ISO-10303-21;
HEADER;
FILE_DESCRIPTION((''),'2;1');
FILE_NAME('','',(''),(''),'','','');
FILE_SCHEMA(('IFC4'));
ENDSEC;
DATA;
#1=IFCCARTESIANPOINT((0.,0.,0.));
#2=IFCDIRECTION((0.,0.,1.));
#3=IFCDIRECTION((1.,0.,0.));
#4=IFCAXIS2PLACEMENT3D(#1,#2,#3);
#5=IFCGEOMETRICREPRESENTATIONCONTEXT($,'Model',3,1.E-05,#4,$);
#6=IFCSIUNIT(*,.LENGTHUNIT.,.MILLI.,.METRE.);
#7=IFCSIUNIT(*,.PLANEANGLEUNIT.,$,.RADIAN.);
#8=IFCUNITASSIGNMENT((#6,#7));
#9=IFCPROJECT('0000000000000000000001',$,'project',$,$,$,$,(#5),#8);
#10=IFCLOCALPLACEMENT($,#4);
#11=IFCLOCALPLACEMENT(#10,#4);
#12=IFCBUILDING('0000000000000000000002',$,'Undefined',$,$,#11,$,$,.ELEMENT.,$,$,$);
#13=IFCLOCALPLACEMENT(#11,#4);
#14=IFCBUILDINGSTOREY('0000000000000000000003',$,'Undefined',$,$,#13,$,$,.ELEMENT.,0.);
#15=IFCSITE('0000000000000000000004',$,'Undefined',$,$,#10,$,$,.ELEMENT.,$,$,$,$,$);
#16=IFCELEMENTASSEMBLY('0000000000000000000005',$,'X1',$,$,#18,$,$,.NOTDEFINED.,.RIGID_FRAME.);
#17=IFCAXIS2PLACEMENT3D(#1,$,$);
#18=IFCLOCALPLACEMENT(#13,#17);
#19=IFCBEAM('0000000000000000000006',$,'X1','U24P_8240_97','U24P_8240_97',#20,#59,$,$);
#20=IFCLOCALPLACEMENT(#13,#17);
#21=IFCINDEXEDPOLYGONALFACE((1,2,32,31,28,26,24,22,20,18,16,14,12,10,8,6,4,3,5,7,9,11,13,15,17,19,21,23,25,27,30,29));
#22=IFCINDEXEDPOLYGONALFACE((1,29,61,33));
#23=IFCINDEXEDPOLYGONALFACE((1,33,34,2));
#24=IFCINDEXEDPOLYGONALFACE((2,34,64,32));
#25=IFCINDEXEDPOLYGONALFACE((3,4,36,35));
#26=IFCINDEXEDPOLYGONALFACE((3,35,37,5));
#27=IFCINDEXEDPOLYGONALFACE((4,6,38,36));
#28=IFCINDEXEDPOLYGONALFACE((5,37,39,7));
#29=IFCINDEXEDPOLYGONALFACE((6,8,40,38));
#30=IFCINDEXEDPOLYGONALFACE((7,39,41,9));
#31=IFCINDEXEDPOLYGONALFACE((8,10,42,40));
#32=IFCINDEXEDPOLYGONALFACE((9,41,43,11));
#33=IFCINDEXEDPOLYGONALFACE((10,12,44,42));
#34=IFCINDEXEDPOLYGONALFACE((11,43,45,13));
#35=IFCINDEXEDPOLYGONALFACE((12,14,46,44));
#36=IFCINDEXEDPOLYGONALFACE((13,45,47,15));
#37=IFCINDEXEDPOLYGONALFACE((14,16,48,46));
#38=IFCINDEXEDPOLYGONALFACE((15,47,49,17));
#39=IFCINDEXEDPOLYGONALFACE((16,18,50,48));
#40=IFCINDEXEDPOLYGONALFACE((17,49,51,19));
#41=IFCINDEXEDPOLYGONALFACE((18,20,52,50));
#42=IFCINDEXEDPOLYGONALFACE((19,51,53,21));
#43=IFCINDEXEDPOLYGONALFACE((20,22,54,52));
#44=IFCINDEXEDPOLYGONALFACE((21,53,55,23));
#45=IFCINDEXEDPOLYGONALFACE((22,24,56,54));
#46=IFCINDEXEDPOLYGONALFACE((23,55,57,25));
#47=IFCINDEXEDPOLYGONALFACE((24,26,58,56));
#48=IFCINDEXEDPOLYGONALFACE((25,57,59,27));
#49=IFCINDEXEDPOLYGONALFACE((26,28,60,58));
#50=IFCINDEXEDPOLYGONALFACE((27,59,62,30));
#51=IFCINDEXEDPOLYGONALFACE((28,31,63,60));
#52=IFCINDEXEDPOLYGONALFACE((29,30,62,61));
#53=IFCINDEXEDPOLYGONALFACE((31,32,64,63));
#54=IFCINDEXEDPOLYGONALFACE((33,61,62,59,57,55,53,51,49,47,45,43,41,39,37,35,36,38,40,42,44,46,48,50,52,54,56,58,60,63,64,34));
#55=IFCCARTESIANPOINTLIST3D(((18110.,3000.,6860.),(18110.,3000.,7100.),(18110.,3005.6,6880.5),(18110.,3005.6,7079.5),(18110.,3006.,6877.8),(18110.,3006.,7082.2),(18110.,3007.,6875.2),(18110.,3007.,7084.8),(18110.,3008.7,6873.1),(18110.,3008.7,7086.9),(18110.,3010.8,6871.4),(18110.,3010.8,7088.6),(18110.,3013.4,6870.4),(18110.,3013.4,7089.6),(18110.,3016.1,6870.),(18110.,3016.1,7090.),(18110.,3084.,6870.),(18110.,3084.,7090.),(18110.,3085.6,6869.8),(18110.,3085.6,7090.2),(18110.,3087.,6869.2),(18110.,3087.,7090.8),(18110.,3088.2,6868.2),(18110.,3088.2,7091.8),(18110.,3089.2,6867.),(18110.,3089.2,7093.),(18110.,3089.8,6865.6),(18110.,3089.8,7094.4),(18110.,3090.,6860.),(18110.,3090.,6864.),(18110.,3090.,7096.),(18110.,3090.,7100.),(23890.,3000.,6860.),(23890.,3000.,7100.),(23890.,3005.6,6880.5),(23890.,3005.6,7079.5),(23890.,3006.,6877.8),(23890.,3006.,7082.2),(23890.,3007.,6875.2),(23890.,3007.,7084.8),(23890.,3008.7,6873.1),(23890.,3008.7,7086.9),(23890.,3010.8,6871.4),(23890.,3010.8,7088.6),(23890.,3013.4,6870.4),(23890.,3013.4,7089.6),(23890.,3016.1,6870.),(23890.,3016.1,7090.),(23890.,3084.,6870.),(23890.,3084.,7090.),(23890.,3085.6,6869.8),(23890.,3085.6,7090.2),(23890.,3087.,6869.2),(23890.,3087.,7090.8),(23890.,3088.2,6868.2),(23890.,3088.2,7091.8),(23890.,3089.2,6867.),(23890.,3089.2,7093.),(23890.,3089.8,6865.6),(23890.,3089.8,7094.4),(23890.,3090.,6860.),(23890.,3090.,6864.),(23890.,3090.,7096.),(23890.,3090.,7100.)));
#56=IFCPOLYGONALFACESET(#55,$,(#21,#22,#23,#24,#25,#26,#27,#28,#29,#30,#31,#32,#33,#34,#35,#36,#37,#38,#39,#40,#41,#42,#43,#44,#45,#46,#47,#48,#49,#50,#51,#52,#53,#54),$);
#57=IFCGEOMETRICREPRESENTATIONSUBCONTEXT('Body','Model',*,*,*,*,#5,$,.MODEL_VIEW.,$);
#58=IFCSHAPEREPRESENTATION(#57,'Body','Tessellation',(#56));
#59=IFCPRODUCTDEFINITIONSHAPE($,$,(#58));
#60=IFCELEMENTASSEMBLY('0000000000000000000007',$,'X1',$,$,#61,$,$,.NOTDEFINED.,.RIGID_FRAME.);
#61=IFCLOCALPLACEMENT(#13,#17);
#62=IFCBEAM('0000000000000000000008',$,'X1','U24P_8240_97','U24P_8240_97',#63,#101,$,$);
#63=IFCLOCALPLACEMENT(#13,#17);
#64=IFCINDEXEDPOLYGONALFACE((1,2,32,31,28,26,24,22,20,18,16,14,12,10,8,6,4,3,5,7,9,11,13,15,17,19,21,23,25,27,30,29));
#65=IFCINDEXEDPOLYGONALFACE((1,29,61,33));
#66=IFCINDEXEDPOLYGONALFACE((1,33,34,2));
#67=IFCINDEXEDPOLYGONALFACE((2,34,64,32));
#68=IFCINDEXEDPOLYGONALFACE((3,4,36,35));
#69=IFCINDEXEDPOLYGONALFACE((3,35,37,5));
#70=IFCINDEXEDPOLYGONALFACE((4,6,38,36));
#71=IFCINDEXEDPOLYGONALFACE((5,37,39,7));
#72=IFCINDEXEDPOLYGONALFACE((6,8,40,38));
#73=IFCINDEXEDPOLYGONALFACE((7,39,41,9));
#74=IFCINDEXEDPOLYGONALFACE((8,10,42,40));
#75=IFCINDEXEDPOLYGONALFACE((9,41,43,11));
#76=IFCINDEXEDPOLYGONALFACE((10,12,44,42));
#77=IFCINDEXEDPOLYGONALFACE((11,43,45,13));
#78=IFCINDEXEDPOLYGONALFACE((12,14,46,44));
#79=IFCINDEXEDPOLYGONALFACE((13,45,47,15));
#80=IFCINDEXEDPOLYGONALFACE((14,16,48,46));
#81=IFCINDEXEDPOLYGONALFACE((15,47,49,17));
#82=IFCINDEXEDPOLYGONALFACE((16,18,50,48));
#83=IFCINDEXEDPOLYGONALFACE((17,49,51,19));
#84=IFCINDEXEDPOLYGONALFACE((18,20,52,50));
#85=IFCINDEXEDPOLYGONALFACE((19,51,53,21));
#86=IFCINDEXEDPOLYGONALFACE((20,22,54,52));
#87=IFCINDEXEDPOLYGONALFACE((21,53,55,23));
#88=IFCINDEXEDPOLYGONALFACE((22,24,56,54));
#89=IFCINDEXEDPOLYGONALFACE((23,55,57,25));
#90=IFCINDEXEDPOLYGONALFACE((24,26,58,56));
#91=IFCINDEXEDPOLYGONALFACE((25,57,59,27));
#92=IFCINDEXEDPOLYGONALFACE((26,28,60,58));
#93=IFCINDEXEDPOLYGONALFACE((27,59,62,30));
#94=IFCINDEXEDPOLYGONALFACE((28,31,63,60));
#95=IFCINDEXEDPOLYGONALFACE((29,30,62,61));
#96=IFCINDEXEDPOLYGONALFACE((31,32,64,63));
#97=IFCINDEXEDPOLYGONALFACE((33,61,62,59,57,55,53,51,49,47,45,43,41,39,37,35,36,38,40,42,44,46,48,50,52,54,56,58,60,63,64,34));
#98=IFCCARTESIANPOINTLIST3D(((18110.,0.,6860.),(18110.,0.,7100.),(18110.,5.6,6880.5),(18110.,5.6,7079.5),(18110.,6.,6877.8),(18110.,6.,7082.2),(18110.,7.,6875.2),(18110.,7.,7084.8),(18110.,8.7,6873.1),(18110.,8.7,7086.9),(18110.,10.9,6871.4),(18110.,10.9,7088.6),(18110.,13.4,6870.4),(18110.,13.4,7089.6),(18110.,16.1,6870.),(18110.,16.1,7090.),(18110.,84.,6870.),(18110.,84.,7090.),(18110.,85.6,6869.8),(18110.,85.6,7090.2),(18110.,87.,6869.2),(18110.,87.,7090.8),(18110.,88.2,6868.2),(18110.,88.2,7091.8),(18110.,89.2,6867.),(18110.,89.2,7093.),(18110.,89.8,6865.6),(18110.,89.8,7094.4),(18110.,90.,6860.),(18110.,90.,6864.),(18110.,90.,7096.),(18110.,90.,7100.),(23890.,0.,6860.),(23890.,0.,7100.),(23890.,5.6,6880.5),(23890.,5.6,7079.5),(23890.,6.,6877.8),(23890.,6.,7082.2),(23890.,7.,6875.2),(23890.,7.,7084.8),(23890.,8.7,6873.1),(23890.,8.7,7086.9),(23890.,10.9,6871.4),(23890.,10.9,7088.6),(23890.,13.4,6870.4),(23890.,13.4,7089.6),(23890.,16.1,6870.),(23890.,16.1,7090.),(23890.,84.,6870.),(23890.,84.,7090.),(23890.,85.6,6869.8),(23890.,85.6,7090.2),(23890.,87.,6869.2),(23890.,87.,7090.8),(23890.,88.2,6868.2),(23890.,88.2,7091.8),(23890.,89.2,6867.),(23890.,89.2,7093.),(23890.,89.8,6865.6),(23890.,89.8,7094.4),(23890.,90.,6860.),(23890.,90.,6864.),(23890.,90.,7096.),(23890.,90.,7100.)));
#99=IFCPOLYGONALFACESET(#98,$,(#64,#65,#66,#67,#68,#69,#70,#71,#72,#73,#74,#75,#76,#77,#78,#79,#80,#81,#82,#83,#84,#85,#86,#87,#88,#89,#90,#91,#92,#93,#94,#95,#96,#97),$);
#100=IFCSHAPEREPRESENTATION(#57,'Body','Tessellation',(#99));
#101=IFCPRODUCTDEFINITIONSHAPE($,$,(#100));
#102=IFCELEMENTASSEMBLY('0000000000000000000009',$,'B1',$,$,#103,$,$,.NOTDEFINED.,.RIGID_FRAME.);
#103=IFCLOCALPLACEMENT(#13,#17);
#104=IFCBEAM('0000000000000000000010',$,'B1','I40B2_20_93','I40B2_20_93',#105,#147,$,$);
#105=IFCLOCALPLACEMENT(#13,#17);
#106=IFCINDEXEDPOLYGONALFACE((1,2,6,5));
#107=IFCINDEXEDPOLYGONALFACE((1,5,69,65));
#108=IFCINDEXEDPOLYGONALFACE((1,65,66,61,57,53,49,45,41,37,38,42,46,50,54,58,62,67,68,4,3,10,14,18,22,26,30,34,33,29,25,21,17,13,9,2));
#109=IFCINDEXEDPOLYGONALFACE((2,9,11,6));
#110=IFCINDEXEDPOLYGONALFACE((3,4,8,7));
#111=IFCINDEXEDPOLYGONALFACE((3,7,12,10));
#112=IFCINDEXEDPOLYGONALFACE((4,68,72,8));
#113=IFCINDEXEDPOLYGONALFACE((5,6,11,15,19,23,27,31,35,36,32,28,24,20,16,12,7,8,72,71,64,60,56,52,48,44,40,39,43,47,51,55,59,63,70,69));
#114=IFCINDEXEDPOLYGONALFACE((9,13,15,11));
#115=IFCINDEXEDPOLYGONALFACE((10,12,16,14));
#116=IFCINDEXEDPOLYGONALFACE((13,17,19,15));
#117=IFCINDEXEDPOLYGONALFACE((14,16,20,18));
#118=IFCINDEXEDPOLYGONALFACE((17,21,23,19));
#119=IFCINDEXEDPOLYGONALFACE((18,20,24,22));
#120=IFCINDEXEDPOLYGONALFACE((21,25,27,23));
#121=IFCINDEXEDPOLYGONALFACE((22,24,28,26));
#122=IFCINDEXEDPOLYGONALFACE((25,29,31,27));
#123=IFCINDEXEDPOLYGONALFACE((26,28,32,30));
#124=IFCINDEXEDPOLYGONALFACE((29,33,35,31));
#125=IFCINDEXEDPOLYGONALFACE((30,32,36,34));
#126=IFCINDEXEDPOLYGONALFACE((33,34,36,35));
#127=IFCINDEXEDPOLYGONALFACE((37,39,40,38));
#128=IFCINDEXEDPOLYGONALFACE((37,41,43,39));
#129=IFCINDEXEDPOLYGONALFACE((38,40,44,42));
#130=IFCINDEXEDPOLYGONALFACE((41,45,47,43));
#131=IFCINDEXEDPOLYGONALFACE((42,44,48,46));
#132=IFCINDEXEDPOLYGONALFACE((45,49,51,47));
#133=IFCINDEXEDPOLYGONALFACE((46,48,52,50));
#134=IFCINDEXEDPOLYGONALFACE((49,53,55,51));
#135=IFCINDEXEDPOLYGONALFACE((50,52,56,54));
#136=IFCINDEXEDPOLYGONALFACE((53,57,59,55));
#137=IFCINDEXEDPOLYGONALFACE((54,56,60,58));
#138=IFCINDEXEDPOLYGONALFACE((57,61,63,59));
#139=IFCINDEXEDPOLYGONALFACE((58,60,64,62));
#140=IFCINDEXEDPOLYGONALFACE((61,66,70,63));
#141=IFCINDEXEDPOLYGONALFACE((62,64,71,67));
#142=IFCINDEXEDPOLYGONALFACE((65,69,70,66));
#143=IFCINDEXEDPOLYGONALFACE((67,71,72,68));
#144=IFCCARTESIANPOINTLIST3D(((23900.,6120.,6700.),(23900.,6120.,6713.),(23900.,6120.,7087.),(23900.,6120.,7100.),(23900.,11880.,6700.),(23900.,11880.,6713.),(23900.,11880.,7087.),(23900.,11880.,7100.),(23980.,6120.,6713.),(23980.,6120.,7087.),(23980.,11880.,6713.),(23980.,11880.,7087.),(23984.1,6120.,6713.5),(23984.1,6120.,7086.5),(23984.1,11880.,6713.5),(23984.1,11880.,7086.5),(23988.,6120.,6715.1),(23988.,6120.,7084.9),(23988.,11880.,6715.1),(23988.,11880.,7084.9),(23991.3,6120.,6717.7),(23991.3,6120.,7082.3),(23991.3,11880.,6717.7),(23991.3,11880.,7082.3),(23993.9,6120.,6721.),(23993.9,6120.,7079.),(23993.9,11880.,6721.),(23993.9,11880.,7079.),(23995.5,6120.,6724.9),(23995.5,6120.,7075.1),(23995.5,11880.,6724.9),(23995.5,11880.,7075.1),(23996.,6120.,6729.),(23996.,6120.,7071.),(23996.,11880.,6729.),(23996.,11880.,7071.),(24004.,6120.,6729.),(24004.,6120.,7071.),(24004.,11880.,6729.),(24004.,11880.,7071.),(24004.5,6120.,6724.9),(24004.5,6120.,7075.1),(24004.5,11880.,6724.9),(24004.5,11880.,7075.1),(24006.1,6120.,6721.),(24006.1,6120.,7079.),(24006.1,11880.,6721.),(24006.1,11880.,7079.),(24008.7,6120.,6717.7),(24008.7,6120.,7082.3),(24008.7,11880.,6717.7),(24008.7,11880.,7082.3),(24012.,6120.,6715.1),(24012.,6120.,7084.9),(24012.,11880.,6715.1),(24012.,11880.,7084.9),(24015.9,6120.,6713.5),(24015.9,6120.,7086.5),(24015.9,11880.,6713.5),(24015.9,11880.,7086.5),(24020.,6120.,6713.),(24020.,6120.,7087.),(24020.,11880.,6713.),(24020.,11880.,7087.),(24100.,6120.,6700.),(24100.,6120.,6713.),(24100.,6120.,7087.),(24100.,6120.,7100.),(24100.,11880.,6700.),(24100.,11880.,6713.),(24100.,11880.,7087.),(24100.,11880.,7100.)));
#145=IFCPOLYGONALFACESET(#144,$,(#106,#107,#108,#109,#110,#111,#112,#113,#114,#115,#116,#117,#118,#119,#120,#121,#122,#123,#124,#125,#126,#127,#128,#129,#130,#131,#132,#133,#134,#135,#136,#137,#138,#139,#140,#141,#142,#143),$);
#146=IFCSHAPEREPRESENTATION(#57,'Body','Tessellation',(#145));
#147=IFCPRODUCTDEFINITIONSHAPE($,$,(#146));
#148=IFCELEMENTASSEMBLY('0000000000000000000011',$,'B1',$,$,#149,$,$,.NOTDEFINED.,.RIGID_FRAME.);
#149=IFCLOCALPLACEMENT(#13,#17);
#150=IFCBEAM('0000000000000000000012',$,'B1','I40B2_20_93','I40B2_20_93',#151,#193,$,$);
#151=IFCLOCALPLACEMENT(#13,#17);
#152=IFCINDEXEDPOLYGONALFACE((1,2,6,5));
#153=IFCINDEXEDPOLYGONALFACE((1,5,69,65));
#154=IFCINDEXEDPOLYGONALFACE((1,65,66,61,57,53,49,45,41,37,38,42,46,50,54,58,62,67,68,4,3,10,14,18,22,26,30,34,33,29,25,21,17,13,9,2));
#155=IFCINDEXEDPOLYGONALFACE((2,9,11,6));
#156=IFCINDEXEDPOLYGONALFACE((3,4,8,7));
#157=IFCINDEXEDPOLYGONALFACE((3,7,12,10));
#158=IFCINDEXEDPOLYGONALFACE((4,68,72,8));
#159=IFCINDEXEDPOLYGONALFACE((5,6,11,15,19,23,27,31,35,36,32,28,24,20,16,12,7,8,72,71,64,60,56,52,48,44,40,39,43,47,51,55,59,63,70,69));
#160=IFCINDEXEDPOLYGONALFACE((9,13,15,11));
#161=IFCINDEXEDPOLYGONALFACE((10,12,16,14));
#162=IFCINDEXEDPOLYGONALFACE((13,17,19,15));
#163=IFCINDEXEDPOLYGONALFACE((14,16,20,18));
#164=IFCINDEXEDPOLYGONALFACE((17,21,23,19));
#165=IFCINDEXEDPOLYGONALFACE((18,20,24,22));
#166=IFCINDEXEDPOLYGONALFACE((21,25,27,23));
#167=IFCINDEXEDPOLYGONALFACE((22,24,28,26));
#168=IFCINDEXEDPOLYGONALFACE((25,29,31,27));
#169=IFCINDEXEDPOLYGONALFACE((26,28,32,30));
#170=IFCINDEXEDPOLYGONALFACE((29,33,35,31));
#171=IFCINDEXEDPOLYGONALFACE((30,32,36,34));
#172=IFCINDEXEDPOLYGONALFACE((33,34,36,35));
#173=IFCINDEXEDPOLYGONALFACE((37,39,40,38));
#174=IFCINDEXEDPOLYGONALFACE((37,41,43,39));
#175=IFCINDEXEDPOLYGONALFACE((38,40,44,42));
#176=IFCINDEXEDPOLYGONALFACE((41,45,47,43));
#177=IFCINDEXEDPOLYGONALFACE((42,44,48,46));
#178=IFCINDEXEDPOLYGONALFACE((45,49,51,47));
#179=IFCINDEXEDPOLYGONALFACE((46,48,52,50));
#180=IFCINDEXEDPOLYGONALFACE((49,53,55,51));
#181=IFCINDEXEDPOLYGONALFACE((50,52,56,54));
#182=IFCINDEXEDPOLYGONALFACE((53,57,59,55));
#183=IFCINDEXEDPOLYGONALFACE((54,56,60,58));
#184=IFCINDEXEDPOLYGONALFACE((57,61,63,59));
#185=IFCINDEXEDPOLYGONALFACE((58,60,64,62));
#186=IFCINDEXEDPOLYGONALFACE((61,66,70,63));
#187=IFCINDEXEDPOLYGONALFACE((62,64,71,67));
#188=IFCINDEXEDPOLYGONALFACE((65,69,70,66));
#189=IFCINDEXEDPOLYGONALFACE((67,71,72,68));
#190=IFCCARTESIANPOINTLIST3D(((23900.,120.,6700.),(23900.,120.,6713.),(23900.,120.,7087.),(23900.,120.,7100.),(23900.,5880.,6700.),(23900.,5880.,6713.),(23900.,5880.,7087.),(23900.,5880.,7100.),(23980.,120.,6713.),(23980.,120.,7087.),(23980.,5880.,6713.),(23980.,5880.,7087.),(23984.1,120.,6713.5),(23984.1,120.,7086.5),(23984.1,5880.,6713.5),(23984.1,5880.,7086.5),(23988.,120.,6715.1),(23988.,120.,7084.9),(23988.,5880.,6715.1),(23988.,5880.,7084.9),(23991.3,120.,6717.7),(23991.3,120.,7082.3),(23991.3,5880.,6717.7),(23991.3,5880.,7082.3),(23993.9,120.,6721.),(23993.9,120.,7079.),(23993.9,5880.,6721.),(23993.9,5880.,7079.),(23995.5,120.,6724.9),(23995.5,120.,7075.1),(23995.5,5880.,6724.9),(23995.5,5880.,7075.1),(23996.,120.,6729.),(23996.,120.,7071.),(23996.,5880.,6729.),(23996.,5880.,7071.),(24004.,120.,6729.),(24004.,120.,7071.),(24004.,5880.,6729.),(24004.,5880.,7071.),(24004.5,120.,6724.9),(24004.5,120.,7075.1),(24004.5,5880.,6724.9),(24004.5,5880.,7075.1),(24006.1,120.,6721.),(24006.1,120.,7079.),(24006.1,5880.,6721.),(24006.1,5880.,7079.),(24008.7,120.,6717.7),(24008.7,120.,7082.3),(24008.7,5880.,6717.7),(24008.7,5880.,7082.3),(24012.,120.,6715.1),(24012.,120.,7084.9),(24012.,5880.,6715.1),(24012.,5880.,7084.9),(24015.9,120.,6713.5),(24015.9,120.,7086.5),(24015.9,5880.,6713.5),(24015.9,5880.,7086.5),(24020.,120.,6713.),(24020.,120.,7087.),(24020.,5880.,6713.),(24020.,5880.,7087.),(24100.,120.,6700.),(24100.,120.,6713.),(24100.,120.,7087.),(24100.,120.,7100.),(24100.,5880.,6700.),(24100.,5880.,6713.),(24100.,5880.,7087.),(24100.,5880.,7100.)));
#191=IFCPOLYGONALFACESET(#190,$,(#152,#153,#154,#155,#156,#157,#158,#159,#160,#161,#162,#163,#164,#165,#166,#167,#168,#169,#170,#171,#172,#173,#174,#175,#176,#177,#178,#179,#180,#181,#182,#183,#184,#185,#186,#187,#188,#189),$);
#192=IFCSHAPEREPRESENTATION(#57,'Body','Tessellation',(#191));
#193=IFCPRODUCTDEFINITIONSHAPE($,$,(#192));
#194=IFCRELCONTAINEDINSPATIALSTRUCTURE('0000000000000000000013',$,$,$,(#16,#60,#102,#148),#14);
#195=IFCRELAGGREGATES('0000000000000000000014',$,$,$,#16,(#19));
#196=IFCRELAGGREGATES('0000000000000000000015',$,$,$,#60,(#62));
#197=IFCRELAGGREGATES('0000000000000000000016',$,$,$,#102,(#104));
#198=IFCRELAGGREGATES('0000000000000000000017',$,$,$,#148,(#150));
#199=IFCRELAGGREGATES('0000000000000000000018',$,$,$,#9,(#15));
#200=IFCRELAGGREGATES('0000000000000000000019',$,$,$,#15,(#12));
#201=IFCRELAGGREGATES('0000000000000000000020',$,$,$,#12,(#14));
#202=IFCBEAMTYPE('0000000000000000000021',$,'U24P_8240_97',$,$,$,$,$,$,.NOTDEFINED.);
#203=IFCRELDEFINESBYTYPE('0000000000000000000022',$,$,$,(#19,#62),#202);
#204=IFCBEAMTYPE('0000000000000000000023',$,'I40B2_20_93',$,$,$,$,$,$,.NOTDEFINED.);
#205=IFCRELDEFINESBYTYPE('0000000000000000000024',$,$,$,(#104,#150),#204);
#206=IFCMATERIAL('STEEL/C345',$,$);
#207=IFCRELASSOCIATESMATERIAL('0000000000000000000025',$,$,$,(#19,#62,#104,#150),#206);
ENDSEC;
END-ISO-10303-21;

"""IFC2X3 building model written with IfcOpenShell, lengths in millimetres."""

from ifc_helpers import new_model, si_unit, frame, origin_with_axes, origin_2d_with_axis, place, context, subcontext, project, spatial, i_section, u_section, extrude, material, type_object, element, aggregate, save


model = new_model("IFC2X3")

# Units and contexts
model_context = context("Model", 3, precision=1e-05, world=origin_with_axes())
body_context = subcontext(model_context, "Body", "Model", "MODEL_VIEW")
ifc_project = project(units=[si_unit("LENGTHUNIT", "METRE", prefix="MILLI"), si_unit("PLANEANGLEUNIT", "RADIAN")], contexts=[model_context])

# Site, building, storey
site_placement = place(None, origin_with_axes())
site = spatial("IfcSite", under=ifc_project, at=site_placement, Name="Undefined", CompositionType="ELEMENT")
building_placement = place(site_placement, origin_with_axes())
building = spatial("IfcBuilding", under=site, at=building_placement, Name="Undefined", CompositionType="ELEMENT")
storey_placement = place(building_placement, origin_with_axes())
storey = spatial("IfcBuildingStorey", under=building, at=storey_placement, Name="Undefined", CompositionType="ELEMENT", Elevation=0.0)

# Element assemblies, beams
ifc_material_1 = material(Name="STEEL/C345")
beam_type_1 = type_object("IfcBeamType", Name="U24P_8240_97", PredefinedType="NOTDEFINED")
assembly_1_placement = place(storey_placement, origin_with_axes())
assembly_1 = element("IfcElementAssembly", 1, at=assembly_1_placement, inside=storey, Name="X1", AssemblyPlace="NOTDEFINED", PredefinedType="RIGID_FRAME")
beam_1_placement = place(assembly_1_placement, frame((18110.0, 3045.0, 6980.0), z_axis=(0.0, 0.0, -1.0), x_axis=(1.0, 0.0, 0.0)))
beam_1 = element("IfcBeam", 2, at=beam_1_placement, type_object=beam_type_1, material=ifc_material_1, Name="X1", Description="U24P_8240_97", ObjectType="U24P_8240_97", context=body_context, shape_type="SweptSolid", body=[
    extrude(u_section(Depth=240.0, FlangeWidth=90.0, WebThickness=5.6, FlangeThickness=10.0, FilletRadius=10.5, EdgeRadius=6.0, at=origin_2d_with_axis()), frame((5780.0, 0.0, 0.0), z_axis=(-1.0, 0.0, 0.0), x_axis=(0.0, -1.0, 0.0)), (0.0, 0.0, 1.0), 5780.0),
])
aggregate(assembly_1, [beam_1])
assembly_2_placement = place(storey_placement, origin_with_axes())
assembly_2 = element("IfcElementAssembly", 3, at=assembly_2_placement, inside=storey, Name="X1", AssemblyPlace="NOTDEFINED", PredefinedType="RIGID_FRAME")
beam_2_placement = place(assembly_2_placement, frame((18110.0, 45.0, 6980.0), z_axis=(0.0, 0.0, -1.0), x_axis=(1.0, 0.0, 0.0)))
beam_2 = element("IfcBeam", 4, at=beam_2_placement, type_object=beam_type_1, material=ifc_material_1, Name="X1", Description="U24P_8240_97", ObjectType="U24P_8240_97", context=body_context, shape_type="SweptSolid", body=[
    extrude(u_section(Depth=240.0, FlangeWidth=90.0, WebThickness=5.6, FlangeThickness=10.0, FilletRadius=10.5, EdgeRadius=6.0, at=origin_2d_with_axis()), frame((5780.0, 0.0, 0.0), z_axis=(-1.0, 0.0, 0.0), x_axis=(0.0, -1.0, 0.0)), (0.0, 0.0, 1.0), 5780.0),
])
aggregate(assembly_2, [beam_2])
assembly_3_placement = place(storey_placement, origin_with_axes())
assembly_3 = element("IfcElementAssembly", 5, at=assembly_3_placement, inside=storey, Name="B1", AssemblyPlace="NOTDEFINED", PredefinedType="RIGID_FRAME")
beam_type_2 = type_object("IfcBeamType", Name="I40B2_20_93", PredefinedType="NOTDEFINED")
beam_3_placement = place(assembly_3_placement, frame((24000.0, 6120.0, 6900.0), z_axis=(0.0, 0.0, 1.0), x_axis=(0.0, 1.0, 0.0)))
beam_3 = element("IfcBeam", 6, at=beam_3_placement, type_object=beam_type_2, material=ifc_material_1, Name="B1", Description="I40B2_20_93", ObjectType="I40B2_20_93", context=body_context, shape_type="SweptSolid", body=[
    extrude(i_section(OverallWidth=200.0, OverallDepth=400.0, WebThickness=8.0, FlangeThickness=13.0, FilletRadius=16.0, at=origin_2d_with_axis()), frame((5760.0, 0.0, 0.0), z_axis=(-1.0, 0.0, 0.0), x_axis=(0.0, -1.0, 0.0)), (0.0, 0.0, 1.0), 5760.0),
])
aggregate(assembly_3, [beam_3])
assembly_4_placement = place(storey_placement, origin_with_axes())
assembly_4 = element("IfcElementAssembly", 7, at=assembly_4_placement, inside=storey, Name="B1", AssemblyPlace="NOTDEFINED", PredefinedType="RIGID_FRAME")
beam_4_placement = place(assembly_4_placement, frame((24000.0, 120.0, 6900.0), z_axis=(0.0, 0.0, 1.0), x_axis=(0.0, 1.0, 0.0)))
beam_4 = element("IfcBeam", 8, at=beam_4_placement, type_object=beam_type_2, material=ifc_material_1, Name="B1", Description="I40B2_20_93", ObjectType="I40B2_20_93", context=body_context, shape_type="SweptSolid", body=[
    extrude(i_section(OverallWidth=200.0, OverallDepth=400.0, WebThickness=8.0, FlangeThickness=13.0, FilletRadius=16.0, at=origin_2d_with_axis()), frame((5760.0, 0.0, 0.0), z_axis=(-1.0, 0.0, 0.0), x_axis=(0.0, -1.0, 0.0)), (0.0, 0.0, 1.0), 5760.0),
])
aggregate(assembly_4, [beam_4])

save(model, "model.ifc")
